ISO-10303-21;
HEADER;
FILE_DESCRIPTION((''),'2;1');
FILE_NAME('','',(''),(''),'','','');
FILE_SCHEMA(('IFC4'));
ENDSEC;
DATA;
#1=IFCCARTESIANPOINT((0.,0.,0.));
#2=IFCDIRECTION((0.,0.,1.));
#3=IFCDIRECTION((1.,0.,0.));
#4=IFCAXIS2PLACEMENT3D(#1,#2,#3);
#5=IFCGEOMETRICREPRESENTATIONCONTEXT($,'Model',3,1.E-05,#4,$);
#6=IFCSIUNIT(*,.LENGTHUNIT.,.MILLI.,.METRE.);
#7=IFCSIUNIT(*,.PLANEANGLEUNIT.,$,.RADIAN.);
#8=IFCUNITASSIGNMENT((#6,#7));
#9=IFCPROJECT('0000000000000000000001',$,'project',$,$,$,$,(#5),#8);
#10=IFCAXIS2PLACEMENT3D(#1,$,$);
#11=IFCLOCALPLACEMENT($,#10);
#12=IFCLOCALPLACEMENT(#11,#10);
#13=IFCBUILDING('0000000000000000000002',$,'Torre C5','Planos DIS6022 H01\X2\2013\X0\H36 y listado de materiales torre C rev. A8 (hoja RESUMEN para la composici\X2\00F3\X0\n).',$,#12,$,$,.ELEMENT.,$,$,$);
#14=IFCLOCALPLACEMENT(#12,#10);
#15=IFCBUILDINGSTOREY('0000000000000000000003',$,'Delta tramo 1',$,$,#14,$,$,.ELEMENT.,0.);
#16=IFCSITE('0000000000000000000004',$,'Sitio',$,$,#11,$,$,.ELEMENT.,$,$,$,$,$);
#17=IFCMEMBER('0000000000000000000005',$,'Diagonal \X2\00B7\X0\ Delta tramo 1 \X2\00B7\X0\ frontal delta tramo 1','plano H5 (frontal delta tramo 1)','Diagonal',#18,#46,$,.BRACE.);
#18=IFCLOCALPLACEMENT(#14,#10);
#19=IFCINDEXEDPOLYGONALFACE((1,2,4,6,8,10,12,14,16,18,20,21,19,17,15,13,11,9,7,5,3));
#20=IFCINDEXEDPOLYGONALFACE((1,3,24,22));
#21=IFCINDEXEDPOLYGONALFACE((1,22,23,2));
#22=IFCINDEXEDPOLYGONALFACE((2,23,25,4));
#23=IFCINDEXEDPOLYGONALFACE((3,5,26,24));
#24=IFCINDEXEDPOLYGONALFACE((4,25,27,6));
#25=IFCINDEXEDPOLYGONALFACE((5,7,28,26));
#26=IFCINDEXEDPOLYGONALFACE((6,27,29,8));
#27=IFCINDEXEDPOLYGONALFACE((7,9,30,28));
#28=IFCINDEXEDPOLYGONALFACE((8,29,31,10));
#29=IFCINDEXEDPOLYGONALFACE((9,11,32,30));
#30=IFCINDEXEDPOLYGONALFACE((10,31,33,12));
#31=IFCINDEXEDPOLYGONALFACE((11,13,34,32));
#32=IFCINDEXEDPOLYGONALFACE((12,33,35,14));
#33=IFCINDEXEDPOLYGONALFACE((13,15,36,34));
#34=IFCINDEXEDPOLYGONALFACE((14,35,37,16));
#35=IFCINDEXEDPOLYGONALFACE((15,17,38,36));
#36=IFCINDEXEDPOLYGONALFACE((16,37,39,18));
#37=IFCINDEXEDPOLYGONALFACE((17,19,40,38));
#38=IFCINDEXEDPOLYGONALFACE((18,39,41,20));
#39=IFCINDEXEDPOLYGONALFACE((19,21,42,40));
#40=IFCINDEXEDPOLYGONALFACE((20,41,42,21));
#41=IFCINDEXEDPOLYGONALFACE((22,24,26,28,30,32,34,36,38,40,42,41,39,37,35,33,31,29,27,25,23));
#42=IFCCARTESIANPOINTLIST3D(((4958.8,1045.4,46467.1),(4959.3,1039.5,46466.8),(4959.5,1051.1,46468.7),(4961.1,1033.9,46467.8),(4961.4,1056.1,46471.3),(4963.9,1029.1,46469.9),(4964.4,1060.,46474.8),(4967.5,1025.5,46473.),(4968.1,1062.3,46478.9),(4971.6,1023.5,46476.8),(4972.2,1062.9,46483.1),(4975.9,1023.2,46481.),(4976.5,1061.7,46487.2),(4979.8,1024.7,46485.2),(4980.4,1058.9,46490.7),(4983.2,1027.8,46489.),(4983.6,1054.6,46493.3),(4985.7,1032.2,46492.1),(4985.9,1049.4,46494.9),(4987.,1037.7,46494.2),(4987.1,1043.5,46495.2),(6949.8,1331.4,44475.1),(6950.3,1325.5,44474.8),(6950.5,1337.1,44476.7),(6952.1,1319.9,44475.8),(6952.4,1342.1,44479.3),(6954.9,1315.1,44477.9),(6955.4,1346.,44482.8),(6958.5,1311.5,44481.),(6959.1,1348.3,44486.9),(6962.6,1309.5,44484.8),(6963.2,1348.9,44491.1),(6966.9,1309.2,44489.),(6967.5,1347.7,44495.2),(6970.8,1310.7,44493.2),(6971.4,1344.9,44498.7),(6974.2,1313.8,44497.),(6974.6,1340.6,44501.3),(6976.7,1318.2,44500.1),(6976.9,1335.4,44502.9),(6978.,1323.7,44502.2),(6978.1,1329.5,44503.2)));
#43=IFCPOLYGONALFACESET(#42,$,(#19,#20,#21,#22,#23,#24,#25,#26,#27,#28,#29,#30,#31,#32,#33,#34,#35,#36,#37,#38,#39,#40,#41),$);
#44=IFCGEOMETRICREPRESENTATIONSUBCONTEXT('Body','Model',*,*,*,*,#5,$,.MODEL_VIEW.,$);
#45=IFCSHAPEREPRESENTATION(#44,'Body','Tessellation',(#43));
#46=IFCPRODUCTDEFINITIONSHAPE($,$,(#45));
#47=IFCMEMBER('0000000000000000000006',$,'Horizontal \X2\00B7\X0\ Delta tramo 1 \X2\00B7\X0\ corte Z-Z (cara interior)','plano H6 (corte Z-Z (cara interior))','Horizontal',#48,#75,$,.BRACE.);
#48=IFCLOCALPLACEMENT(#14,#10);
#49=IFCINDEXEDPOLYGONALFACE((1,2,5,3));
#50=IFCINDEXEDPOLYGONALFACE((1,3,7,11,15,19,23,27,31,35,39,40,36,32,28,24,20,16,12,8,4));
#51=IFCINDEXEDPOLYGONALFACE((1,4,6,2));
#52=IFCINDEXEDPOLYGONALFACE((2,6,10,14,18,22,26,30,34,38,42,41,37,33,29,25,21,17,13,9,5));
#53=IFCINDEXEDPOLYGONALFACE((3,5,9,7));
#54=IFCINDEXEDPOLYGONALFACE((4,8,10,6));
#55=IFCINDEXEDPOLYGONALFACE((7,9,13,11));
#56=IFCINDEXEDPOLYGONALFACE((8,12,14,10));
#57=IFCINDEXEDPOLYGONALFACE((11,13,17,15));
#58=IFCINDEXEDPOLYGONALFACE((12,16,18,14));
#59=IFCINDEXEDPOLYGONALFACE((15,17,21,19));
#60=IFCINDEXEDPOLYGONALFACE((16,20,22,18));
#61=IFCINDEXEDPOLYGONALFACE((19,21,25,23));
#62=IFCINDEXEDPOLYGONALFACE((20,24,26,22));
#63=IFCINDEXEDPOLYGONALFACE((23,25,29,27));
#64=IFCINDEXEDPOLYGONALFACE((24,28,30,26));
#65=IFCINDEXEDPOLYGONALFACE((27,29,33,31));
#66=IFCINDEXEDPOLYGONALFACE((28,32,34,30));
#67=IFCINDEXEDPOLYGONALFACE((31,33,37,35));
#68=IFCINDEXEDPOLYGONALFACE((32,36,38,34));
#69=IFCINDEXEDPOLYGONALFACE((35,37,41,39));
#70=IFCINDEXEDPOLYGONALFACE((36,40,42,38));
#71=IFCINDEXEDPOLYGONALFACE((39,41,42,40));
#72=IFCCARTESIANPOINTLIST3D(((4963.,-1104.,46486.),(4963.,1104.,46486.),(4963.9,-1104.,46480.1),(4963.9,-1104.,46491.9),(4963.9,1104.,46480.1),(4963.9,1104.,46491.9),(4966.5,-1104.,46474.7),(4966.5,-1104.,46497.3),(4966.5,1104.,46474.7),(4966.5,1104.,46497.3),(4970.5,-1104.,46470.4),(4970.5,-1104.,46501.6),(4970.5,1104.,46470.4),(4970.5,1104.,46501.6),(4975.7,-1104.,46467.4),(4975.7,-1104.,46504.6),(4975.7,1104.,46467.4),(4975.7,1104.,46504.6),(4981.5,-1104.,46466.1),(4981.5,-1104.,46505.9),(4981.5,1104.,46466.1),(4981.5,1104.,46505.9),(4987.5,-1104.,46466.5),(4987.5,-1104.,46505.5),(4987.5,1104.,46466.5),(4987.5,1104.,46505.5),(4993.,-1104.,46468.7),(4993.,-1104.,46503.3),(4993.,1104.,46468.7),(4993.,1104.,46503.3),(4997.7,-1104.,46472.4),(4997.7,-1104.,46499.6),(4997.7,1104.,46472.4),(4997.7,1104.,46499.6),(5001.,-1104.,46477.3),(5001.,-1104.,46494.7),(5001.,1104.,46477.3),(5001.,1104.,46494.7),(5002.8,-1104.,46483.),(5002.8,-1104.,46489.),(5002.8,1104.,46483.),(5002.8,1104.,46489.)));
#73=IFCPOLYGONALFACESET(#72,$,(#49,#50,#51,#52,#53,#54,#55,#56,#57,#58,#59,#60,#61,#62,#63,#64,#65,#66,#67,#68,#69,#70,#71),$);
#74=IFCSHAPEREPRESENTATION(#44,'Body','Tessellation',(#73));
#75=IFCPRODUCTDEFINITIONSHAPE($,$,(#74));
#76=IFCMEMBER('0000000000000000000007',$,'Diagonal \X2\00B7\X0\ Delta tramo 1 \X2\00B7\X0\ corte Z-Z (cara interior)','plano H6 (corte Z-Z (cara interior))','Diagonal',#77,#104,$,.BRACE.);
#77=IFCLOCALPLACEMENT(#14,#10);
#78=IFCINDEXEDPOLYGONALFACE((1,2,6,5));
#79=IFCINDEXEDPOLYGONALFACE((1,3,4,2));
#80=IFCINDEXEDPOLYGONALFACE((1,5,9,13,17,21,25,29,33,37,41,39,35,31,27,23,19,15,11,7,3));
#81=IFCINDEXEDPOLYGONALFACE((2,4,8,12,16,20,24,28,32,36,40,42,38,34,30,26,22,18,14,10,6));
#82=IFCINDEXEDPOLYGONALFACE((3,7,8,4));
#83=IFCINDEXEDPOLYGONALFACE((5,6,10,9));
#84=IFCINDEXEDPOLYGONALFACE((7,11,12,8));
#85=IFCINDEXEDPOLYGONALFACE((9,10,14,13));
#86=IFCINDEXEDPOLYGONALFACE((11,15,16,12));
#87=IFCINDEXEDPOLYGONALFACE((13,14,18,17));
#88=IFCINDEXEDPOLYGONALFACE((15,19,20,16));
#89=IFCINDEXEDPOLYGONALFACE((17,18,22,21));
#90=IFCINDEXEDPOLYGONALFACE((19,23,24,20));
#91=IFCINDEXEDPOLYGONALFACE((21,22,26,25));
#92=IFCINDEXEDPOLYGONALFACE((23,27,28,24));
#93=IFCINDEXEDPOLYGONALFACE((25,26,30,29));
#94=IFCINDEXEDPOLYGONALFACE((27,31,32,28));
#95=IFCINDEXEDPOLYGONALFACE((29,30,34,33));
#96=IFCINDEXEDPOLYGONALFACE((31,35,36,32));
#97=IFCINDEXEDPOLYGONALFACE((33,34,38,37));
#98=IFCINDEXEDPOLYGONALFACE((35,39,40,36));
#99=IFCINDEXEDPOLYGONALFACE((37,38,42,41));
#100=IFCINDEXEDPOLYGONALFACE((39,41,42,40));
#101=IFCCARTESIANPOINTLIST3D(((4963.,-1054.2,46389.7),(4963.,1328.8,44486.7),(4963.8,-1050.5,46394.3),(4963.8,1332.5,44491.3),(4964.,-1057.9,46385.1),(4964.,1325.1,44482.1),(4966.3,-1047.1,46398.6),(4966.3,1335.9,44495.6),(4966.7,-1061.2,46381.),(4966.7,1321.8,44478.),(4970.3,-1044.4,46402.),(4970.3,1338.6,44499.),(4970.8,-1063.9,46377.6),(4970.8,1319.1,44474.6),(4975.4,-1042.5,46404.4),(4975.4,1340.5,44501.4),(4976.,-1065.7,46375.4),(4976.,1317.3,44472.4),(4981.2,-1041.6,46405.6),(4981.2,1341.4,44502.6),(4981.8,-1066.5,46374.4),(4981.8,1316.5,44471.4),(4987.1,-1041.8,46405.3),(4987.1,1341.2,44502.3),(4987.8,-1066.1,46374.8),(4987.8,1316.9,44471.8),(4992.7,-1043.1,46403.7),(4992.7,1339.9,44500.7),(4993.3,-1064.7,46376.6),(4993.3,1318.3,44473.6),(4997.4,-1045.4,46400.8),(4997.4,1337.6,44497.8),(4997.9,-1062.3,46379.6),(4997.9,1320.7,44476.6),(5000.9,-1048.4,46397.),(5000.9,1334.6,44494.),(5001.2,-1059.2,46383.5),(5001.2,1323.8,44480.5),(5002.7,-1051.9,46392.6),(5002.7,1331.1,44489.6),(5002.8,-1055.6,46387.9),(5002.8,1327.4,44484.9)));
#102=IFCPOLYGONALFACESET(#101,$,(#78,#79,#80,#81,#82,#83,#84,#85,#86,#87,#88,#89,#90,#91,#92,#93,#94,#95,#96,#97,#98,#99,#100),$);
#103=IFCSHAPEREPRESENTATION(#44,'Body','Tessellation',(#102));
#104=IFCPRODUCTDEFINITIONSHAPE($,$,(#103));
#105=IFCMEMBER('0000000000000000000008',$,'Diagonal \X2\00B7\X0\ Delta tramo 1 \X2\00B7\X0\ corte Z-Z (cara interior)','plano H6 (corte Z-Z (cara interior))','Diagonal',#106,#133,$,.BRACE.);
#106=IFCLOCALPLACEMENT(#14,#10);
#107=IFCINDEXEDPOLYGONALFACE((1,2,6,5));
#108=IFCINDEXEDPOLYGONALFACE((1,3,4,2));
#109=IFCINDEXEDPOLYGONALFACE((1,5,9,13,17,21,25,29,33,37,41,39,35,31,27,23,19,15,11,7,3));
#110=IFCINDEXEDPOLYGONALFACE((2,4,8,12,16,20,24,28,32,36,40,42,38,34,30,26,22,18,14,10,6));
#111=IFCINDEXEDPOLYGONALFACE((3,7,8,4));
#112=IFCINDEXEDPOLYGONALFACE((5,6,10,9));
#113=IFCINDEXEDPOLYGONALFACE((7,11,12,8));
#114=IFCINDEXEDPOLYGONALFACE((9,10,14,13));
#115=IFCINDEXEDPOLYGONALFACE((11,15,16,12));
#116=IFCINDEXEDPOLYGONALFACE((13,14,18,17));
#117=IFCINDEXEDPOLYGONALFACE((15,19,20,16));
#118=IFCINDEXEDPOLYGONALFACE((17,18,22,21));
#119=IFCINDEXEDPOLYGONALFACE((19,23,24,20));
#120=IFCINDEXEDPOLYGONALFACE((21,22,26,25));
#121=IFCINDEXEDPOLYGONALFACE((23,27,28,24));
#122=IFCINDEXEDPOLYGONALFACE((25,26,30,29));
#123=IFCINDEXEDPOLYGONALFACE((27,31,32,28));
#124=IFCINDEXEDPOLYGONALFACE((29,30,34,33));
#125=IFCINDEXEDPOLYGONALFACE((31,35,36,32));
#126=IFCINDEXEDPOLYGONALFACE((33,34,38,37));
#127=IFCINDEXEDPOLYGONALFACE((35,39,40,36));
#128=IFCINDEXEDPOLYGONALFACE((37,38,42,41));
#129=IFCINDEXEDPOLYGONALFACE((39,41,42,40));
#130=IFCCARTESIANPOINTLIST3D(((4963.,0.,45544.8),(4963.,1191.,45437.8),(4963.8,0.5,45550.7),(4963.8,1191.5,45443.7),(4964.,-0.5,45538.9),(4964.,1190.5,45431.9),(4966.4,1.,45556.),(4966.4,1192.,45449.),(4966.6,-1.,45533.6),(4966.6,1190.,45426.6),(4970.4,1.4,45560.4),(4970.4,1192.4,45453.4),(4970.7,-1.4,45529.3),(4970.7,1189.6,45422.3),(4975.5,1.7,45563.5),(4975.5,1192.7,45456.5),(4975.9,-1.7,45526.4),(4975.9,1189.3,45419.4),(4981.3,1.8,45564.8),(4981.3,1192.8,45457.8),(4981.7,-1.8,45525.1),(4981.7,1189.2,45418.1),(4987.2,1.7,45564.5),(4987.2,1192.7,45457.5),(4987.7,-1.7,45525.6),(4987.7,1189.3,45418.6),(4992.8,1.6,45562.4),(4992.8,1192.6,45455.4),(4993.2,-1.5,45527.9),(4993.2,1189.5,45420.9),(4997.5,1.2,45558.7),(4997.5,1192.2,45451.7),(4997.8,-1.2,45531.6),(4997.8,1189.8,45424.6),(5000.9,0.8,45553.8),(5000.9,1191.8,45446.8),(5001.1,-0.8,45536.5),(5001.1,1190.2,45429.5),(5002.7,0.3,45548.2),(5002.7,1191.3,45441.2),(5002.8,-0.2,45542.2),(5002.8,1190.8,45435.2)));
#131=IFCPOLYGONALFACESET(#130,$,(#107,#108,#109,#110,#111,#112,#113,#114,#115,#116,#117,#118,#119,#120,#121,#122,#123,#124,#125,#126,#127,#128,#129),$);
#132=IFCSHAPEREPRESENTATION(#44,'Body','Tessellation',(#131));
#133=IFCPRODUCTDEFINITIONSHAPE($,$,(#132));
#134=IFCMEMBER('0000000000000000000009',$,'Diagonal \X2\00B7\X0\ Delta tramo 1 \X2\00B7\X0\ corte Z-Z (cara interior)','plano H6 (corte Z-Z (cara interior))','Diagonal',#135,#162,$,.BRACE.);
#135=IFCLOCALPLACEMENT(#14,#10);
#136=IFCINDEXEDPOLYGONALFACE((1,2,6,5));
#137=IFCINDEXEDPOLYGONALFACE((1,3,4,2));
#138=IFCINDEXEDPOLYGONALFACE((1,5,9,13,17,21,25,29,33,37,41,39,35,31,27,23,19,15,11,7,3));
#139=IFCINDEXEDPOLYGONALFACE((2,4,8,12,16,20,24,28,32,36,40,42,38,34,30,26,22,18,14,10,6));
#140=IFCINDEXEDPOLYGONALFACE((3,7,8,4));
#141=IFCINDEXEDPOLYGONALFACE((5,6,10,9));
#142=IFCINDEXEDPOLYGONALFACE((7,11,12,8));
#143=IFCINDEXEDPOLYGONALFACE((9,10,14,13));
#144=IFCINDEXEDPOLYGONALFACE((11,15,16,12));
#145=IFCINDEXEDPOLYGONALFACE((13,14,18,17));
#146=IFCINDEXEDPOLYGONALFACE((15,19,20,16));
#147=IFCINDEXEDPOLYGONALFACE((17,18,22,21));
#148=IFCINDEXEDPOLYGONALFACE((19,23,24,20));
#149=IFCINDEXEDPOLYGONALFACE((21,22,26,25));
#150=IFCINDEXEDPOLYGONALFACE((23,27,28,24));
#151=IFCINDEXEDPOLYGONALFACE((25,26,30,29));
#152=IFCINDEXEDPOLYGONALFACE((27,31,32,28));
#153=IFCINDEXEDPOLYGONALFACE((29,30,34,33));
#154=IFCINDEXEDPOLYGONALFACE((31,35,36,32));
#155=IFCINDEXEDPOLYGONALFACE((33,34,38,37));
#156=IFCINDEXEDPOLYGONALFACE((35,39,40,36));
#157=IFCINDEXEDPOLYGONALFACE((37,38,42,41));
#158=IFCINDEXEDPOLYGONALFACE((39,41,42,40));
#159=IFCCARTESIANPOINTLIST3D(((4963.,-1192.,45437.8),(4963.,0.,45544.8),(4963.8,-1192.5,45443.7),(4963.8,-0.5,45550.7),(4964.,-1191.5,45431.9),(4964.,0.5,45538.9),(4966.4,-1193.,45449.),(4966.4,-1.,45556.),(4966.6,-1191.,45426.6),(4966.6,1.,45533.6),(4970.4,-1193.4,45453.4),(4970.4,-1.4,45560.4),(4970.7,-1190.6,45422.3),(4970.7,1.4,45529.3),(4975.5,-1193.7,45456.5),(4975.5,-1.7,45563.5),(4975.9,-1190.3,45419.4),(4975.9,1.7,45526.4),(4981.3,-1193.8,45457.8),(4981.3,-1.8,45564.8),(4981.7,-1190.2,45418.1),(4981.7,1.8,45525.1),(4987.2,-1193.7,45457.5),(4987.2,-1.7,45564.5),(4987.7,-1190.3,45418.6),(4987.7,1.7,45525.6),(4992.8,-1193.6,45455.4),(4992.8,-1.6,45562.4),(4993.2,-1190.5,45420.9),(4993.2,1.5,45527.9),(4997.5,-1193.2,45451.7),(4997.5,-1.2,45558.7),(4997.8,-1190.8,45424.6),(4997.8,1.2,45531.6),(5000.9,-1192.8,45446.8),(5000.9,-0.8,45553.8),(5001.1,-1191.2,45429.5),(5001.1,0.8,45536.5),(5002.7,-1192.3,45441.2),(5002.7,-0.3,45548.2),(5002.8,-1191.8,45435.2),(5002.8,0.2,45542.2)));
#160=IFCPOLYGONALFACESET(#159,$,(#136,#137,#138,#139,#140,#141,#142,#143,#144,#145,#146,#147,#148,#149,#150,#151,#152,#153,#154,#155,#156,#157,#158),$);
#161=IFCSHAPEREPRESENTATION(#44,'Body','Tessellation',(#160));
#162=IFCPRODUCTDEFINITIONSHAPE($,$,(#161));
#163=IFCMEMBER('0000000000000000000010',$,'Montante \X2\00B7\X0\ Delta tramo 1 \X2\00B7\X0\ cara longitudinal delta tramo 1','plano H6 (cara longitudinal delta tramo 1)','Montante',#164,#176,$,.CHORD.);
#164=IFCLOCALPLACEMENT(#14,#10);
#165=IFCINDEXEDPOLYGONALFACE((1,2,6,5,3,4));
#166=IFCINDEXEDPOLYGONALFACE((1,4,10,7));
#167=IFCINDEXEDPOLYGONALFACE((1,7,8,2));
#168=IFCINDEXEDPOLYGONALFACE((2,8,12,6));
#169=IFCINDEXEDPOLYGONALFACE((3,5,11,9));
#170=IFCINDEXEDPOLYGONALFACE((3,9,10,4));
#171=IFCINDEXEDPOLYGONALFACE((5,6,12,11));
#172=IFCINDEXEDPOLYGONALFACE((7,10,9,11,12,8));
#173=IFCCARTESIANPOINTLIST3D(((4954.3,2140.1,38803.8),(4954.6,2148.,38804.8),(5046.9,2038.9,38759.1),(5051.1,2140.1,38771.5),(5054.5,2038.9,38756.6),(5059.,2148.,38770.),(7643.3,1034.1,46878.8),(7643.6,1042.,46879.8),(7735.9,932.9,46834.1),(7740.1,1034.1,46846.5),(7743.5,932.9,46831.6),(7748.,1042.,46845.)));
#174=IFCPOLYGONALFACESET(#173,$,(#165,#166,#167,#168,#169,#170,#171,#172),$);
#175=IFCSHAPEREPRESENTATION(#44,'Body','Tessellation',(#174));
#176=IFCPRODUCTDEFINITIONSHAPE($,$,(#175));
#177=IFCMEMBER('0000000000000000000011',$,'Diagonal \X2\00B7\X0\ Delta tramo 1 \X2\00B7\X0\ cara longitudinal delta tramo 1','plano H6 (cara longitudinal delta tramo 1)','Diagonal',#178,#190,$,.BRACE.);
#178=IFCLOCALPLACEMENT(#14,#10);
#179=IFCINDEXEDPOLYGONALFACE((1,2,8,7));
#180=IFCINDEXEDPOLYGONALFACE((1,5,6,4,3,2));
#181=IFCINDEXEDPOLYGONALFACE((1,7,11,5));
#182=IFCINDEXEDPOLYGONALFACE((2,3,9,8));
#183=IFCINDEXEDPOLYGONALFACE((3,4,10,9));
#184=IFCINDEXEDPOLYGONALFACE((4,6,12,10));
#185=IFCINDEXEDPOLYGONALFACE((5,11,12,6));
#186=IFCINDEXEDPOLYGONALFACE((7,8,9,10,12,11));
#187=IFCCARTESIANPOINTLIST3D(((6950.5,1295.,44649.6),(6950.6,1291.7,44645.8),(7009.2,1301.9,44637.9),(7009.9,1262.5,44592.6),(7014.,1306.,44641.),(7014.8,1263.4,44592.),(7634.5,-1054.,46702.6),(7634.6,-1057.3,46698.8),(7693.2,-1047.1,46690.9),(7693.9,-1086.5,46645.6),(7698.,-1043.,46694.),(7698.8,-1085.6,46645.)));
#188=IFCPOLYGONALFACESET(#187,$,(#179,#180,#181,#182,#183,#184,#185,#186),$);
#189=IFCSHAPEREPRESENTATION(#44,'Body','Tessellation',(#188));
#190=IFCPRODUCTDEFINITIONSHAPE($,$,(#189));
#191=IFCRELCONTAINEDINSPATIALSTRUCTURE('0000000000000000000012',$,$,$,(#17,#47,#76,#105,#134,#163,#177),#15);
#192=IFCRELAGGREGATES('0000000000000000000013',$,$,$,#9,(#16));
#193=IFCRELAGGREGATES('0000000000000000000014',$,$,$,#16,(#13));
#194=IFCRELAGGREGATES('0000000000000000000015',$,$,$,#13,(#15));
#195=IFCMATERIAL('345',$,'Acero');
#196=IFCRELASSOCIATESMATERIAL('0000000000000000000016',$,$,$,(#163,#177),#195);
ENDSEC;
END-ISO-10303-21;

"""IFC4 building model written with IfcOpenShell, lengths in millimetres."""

from ifc_helpers import new_model, si_unit, frame, frame_2d, origin, origin_with_axes, place, context, subcontext, project, spatial, circle, l_section, extrude, material, element, save


model = new_model("IFC4")

# Units and contexts
model_context = context("Model", 3, precision=1e-05, world=origin_with_axes())
body_context = subcontext(model_context, "Body", "Model", "MODEL_VIEW")
ifc_project = project(units=[si_unit("LENGTHUNIT", "METRE", prefix="MILLI"), si_unit("PLANEANGLEUNIT", "RADIAN")], contexts=[model_context])

# Site, building, storey
site_placement = place(None, origin())
site = spatial("IfcSite", under=ifc_project, at=site_placement, Name="Sitio", CompositionType="ELEMENT")
building_placement = place(site_placement, origin())
building = spatial("IfcBuilding", under=site, at=building_placement, Name="Torre C5", Description="Planos DIS6022 H01–H36 y listado de materiales torre C rev. A8 (hoja RESUMEN para la composición).", CompositionType="ELEMENT")
storey_placement = place(building_placement, origin())
storey = spatial("IfcBuildingStorey", under=building, at=storey_placement, Name="Delta tramo 1", CompositionType="ELEMENT", Elevation=0.0)

# Members
ifc_material = material(Name="345", Category="Acero")
for number, where, z_axis, x_axis, name in (
    (1, (4973.0, 1043.0, 46481.0), (0.703312, 0.101028, -0.703666), (-0.683723, -0.174854, -0.708484), "Diagonal · Delta tramo 1 · frontal delta tramo 1"),
):
    element("IfcMember", number, at=place(storey_placement, frame(where, z_axis=z_axis, x_axis=x_axis)), inside=storey, Name=name, Description="plano H5 (frontal delta tramo 1)", ObjectType="Diagonal", PredefinedType="BRACE", context=body_context, shape_type="SweptSolid", body=[
        extrude(circle(Radius=20.0), None, (0.0, 0.0, 1.0), 2830.9),
    ])
member_1_placement = place(storey_placement, frame((4983.0, -1104.0, 46486.0), z_axis=(0.0, 1.0, 0.0), x_axis=(-1.0, 0.0, 0.0)))
element("IfcMember", 2, at=member_1_placement, inside=storey, Name="Horizontal · Delta tramo 1 · corte Z-Z (cara interior)", Description="plano H6 (corte Z-Z (cara interior))", ObjectType="Horizontal", PredefinedType="BRACE", context=body_context, shape_type="SweptSolid", body=[
    extrude(circle(Radius=20.0), None, (0.0, 0.0, 1.0), 2208.0),
])
member_2_placement = place(storey_placement, frame((4983.0, -1054.0, 46390.0), z_axis=(0.0, 0.781412, -0.624015), x_axis=(-0.999852, -0.010743, -0.013453)))
element("IfcMember", 3, at=member_2_placement, inside=storey, Name="Diagonal · Delta tramo 1 · corte Z-Z (cara interior)", Description="plano H6 (corte Z-Z (cara interior))", ObjectType="Diagonal", PredefinedType="BRACE", context=body_context, shape_type="SweptSolid", body=[
    extrude(circle(Radius=20.0), None, (0.0, 0.0, 1.0), 3049.6),
])
member_3_placement = place(storey_placement, frame((4983.0, 1191.0, 45438.0), z_axis=(0.0, -0.995989, 0.08948), x_axis=(-0.999943, -0.000957, -0.01065)))
element("IfcMember", 4, at=member_3_placement, inside=storey, Name="Diagonal · Delta tramo 1 · corte Z-Z (cara interior)", Description="plano H6 (corte Z-Z (cara interior))", ObjectType="Diagonal", PredefinedType="BRACE", context=body_context, shape_type="SweptSolid", body=[
    extrude(circle(Radius=20.0), None, (0.0, 0.0, 1.0), 1195.8),
])
member_4_placement = place(storey_placement, frame((4983.0, -1192.0, 45438.0), z_axis=(0.0, 0.995995, 0.089406), x_axis=(-0.999943, 0.000956, -0.01065)))
element("IfcMember", 5, at=member_4_placement, inside=storey, Name="Diagonal · Delta tramo 1 · corte Z-Z (cara interior)", Description="plano H6 (corte Z-Z (cara interior))", ObjectType="Diagonal", PredefinedType="BRACE", context=body_context, shape_type="SweptSolid", body=[
    extrude(circle(Radius=20.0), None, (0.0, 0.0, 1.0), 1196.8),
])
member_5_placement = place(storey_placement, frame((7748.0, 1042.0, 46845.0), z_axis=(-0.313311, 0.128867, -0.940866), x_axis=(-0.040715, -0.991662, -0.122266)))
element("IfcMember", 6, at=member_5_placement, inside=storey, material=ifc_material, Name="Montante · Delta tramo 1 · cara longitudinal delta tramo 1", Description="plano H6 (cara longitudinal delta tramo 1)", ObjectType="Montante", PredefinedType="CHORD", context=body_context, shape_type="SweptSolid", body=[
    extrude(l_section(Depth=110.0, Width=110.0, Thickness=8.0, at=frame_2d((55.0, 55.0))), None, (0.0, 0.0, 1.0), 8582.5),
])
member_6_placement = place(storey_placement, frame((7014.0, 1306.0, 44641.0), z_axis=(0.214164, -0.735484, 0.642805), x_axis=(-0.976727, -0.169145, 0.131884)))
element("IfcMember", 7, at=member_6_placement, inside=storey, material=ifc_material, Name="Diagonal · Delta tramo 1 · cara longitudinal delta tramo 1", Description="plano H6 (cara longitudinal delta tramo 1)", ObjectType="Diagonal", PredefinedType="BRACE", context=body_context, shape_type="SweptSolid", body=[
    extrude(l_section(Depth=65.0, Width=65.0, Thickness=5.0, at=frame_2d((32.5, 32.5))), None, (0.0, 0.0, 1.0), 3193.8),
])

save(model, "model.ifc")
